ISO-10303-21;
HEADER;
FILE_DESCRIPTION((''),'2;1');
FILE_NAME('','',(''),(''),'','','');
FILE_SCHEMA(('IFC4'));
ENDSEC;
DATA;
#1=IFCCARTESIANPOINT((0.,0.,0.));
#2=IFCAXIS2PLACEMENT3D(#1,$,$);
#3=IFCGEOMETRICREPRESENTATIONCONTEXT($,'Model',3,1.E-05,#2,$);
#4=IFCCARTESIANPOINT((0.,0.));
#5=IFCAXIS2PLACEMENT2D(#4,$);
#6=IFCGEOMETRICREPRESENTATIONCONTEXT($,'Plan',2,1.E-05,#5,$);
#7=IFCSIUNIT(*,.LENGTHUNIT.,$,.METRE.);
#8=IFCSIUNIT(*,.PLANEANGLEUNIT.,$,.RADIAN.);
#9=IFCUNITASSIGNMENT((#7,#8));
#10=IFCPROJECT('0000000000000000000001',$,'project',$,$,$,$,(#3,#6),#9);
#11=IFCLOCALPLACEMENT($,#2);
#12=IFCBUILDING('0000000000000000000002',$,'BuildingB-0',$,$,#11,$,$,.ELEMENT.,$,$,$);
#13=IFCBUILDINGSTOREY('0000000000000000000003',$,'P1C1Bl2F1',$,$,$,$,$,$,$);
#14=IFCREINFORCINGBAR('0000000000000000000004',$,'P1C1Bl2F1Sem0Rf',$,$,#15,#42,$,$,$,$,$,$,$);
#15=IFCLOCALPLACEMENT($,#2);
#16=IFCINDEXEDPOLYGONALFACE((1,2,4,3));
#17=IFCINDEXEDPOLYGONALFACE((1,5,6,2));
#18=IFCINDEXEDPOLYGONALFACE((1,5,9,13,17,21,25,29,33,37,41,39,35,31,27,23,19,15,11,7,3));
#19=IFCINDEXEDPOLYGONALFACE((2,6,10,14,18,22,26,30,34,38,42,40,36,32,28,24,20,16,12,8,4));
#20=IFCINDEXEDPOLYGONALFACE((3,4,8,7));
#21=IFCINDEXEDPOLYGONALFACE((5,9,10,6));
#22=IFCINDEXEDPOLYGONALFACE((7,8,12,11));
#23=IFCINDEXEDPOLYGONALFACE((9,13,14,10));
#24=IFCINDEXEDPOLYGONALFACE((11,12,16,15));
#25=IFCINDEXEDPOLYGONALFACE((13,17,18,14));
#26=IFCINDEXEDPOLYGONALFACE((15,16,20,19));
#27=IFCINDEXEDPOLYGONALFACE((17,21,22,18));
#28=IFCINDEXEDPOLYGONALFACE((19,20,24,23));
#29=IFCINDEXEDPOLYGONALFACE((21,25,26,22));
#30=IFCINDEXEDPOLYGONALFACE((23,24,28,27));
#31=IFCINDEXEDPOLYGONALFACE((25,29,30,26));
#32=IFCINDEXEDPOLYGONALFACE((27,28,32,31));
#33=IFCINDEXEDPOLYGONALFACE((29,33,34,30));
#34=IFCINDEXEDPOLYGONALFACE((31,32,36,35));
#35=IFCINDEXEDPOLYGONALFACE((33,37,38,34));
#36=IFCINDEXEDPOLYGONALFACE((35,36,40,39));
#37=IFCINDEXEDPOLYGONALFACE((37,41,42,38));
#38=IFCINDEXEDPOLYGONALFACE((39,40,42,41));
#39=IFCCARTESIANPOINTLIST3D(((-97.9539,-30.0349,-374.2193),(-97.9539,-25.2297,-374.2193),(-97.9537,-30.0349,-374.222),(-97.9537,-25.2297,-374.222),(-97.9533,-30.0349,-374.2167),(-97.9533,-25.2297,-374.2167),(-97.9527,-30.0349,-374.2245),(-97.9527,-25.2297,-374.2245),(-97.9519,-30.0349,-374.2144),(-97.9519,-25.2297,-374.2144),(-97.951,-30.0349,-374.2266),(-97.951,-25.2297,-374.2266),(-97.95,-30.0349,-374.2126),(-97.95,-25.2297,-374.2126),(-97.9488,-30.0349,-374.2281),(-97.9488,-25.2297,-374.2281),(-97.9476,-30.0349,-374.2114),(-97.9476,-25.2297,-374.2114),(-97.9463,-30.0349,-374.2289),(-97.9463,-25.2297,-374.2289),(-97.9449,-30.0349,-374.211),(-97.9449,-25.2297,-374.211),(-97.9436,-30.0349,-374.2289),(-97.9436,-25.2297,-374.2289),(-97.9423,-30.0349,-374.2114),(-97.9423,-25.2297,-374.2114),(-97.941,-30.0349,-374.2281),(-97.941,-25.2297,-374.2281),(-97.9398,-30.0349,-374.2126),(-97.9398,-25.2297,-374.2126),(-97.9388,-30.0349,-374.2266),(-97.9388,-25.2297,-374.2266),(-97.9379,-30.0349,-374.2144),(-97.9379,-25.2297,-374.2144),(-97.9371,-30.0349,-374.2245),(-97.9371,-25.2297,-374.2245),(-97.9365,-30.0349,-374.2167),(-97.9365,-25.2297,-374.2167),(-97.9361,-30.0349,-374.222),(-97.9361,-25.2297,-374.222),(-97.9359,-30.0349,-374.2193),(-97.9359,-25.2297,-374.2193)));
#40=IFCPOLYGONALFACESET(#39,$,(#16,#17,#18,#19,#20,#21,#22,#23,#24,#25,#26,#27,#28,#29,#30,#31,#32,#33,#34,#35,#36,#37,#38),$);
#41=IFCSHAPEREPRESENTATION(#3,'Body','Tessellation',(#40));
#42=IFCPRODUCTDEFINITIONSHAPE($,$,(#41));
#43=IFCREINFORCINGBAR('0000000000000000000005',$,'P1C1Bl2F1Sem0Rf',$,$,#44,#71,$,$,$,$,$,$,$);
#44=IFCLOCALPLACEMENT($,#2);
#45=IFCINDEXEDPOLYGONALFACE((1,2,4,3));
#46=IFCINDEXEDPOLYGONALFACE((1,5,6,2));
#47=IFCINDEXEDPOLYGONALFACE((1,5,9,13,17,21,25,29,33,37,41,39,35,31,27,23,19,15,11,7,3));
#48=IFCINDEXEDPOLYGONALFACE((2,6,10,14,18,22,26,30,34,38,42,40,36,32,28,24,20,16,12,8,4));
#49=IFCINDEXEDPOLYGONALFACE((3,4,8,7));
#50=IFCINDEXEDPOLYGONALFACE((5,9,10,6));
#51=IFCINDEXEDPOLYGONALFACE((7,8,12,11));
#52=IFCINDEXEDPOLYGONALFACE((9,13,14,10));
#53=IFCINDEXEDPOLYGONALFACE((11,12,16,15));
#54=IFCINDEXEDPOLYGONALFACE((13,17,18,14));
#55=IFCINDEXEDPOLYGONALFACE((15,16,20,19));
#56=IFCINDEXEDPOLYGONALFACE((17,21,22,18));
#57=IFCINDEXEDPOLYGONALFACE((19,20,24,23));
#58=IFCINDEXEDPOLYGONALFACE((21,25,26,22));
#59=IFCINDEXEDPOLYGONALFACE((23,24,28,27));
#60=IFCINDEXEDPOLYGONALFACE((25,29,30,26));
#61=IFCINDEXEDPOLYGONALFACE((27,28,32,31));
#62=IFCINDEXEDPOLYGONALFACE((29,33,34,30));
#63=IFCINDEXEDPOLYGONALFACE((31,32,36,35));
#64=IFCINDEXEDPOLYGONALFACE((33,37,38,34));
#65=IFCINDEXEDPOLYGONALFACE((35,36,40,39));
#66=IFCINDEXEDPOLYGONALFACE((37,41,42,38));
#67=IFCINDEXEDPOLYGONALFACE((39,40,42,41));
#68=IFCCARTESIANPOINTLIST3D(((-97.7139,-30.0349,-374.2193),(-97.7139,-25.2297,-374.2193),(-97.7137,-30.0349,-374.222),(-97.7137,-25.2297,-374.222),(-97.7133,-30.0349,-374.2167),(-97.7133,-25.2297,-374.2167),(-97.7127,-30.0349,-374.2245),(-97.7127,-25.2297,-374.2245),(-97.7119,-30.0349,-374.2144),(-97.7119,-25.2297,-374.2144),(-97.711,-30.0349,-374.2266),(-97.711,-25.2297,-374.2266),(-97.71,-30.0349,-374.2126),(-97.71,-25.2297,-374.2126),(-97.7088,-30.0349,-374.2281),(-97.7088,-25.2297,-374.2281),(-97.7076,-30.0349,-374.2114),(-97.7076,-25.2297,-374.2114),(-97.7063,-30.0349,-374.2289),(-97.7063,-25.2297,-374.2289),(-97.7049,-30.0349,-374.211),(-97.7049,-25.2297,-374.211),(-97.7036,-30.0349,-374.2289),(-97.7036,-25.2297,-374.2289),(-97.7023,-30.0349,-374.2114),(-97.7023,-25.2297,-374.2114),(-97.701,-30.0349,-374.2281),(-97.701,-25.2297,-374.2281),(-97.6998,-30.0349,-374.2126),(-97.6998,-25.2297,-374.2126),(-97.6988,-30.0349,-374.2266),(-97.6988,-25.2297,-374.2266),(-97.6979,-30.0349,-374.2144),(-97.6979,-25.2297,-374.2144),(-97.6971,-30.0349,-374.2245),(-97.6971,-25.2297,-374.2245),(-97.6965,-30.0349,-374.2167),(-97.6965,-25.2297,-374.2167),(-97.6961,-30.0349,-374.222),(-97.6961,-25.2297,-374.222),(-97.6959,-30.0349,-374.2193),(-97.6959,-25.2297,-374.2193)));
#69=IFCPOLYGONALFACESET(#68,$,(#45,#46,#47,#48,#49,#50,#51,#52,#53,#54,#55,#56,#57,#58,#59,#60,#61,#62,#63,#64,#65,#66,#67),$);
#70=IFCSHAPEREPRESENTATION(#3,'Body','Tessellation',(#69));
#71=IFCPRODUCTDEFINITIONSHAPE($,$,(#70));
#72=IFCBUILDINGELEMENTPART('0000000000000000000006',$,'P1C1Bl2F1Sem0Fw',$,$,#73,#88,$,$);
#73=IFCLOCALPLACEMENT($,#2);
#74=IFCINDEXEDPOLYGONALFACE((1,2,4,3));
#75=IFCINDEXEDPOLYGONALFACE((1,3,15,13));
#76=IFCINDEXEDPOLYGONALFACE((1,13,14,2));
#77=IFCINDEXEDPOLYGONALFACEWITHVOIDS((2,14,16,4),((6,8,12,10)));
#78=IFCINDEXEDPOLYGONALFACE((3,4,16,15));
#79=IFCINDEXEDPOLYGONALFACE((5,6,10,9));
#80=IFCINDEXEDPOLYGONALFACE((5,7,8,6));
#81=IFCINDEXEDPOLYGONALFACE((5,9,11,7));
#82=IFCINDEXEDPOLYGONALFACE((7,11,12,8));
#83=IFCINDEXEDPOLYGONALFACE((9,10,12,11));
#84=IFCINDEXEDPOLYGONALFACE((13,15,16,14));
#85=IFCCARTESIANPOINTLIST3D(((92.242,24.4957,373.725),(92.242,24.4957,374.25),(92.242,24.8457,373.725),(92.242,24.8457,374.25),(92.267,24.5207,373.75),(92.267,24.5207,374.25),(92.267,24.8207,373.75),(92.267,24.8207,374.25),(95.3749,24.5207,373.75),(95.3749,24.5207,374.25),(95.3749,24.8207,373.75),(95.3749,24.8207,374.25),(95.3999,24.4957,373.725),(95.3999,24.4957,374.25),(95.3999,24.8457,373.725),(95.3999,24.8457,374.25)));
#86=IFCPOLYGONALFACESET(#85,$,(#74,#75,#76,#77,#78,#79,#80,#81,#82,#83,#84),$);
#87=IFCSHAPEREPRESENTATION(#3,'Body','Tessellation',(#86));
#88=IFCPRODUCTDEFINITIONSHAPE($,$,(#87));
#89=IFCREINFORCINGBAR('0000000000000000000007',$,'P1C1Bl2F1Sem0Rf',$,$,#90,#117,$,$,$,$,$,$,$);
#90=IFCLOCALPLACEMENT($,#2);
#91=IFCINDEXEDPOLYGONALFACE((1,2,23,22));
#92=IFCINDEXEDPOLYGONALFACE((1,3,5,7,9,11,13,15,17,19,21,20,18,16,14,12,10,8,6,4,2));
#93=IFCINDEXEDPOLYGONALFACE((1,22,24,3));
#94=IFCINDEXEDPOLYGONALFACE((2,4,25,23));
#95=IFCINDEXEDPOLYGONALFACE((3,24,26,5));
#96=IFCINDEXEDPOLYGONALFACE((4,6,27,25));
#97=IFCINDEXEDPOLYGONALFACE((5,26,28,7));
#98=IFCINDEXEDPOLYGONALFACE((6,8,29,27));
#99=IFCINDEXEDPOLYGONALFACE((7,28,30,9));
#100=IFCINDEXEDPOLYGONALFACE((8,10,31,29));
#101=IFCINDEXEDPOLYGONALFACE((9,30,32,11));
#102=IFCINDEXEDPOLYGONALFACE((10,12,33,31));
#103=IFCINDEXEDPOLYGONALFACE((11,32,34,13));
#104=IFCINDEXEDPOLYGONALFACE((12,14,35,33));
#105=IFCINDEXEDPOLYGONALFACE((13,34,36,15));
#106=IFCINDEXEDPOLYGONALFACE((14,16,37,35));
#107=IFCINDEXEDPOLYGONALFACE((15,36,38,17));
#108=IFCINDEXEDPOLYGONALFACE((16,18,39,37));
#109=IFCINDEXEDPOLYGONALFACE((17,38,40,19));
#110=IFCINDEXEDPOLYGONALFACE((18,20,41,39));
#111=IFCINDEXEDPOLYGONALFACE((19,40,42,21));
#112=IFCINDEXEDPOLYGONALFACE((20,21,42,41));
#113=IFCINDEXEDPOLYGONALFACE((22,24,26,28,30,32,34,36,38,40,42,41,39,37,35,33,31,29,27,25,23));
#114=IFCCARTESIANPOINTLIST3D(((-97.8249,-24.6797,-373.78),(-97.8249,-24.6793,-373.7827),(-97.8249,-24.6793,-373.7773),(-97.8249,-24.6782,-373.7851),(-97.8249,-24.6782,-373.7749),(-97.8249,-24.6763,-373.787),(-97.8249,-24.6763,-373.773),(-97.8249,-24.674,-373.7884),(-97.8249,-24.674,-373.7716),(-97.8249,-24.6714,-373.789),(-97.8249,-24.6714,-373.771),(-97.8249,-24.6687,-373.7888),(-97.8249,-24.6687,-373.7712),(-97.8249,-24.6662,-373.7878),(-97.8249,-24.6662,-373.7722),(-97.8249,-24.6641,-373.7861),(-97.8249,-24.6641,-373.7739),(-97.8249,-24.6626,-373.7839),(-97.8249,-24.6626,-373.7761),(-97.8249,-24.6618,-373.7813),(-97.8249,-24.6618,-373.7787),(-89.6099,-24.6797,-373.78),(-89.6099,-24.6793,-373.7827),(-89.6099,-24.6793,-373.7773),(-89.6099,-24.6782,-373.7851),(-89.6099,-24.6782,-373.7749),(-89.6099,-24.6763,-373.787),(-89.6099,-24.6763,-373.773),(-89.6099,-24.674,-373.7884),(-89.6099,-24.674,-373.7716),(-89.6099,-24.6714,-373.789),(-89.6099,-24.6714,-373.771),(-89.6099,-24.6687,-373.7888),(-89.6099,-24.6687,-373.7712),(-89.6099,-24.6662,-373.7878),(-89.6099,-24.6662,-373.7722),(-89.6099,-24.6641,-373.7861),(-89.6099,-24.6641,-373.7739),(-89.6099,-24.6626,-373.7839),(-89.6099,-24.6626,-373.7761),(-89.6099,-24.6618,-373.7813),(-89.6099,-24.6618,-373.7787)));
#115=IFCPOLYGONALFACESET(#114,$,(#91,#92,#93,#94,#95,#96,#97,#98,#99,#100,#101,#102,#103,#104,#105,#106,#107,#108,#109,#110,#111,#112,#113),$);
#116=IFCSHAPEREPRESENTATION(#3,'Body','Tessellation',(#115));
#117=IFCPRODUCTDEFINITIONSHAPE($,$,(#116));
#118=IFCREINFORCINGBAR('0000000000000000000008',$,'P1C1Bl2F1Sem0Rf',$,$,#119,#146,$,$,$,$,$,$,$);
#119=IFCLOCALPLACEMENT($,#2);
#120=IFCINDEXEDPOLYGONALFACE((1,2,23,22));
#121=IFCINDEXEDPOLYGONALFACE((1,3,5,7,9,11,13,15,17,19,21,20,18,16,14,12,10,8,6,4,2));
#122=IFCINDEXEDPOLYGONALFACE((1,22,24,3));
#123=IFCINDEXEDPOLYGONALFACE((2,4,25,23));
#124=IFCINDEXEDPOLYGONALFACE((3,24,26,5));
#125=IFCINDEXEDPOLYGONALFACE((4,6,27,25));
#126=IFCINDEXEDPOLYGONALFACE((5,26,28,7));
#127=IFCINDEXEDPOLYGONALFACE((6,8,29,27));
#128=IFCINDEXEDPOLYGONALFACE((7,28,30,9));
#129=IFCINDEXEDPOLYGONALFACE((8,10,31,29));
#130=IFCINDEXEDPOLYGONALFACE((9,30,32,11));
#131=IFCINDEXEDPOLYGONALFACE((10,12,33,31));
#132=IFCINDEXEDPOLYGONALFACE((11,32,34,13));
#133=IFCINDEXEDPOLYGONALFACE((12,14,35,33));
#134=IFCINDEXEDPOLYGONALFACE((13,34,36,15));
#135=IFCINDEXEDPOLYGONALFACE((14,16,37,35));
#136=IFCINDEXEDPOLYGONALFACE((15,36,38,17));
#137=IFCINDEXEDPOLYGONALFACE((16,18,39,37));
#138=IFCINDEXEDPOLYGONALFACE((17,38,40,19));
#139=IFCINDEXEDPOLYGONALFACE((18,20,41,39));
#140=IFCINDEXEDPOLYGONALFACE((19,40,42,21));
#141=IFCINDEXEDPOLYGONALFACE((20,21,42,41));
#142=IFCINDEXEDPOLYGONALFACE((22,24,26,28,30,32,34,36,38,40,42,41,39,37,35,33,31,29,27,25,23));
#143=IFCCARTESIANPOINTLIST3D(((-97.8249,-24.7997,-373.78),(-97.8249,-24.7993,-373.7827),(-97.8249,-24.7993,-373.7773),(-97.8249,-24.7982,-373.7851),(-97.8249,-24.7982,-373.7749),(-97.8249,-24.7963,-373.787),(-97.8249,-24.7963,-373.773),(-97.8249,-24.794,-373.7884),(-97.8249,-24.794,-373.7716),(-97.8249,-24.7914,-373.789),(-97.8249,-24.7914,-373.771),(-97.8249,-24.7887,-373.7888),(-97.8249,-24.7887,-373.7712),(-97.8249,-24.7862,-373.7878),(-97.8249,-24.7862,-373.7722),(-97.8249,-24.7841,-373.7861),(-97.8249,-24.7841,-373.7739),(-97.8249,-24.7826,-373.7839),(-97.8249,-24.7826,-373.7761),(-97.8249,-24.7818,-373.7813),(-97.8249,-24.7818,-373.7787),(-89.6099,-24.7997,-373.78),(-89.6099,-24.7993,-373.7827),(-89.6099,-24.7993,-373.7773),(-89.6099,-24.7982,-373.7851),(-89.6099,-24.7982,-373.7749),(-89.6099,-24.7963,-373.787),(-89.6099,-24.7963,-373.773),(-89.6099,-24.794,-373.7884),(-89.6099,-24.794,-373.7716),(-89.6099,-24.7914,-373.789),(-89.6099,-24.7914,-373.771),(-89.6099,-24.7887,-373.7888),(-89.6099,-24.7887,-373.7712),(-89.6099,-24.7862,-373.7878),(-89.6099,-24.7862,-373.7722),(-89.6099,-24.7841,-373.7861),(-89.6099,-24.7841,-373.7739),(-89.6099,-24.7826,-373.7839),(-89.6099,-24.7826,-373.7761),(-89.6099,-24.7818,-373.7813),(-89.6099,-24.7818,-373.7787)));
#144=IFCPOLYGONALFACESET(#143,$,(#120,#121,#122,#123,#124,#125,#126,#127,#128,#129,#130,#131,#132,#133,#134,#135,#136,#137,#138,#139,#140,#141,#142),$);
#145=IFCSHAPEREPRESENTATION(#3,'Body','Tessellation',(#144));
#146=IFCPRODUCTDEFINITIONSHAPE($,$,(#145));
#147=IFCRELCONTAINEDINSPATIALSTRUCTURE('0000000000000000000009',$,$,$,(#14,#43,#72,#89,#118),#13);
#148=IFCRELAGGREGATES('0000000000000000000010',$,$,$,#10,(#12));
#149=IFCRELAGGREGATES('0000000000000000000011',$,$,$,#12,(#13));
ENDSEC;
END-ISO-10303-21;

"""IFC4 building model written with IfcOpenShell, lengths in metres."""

from ifc_helpers import new_model, entity, si_unit, origin, origin_2d, place, context, project, spatial, polyline, outline, extrude, element, save


model = new_model("IFC4")

# Units and contexts
model_context = context("Model", 3, precision=1e-05, world=origin())
plan_context = context("Plan", 2, precision=1e-05, world=origin_2d())
ifc_project = project(units=[si_unit("LENGTHUNIT", "METRE"), si_unit("PLANEANGLEUNIT", "RADIAN")], contexts=[model_context, plan_context])

# Building, storey
building_placement = place(None, origin())
building = spatial("IfcBuilding", under=ifc_project, at=building_placement, Name="BuildingB-0", CompositionType="ELEMENT")
storey = spatial("IfcBuildingStorey", under=building, Name="P1C1Bl2F1")

# Reinforcing bars
element("IfcReinforcingBar", 1, inside=storey, Name="P1C1Bl2F1Sem0Rf", context=model_context, shape_type="SweptSolid", body=[
    entity("IfcSurfaceCurveSweptAreaSolid", entity("IfcCircleProfileDef", "AREA", None, None, 0.009), None, entity("IfcPolyline", [entity("IfcCartesianPoint", [97.9449, 25.2297, 374.22]), entity("IfcCartesianPoint", [97.9449, 30.0349, 374.22])]), None, None, entity("IfcPlane", entity("IfcAxis2Placement3D", entity("IfcCartesianPoint", [97.9449, 25.2297, 374.22]), entity("IfcDirection", [0.0, 0.0, 1.0]), entity("IfcDirection", [1.0, 0.0, 0.0])))),
])
element("IfcReinforcingBar", 2, inside=storey, Name="P1C1Bl2F1Sem0Rf", context=model_context, shape_type="SweptSolid", body=[
    entity("IfcSurfaceCurveSweptAreaSolid", entity("IfcCircleProfileDef", "AREA", None, None, 0.009), None, entity("IfcPolyline", [entity("IfcCartesianPoint", [97.7049, 25.2297, 374.22]), entity("IfcCartesianPoint", [97.7049, 30.0349, 374.22])]), None, None, entity("IfcPlane", entity("IfcAxis2Placement3D", entity("IfcCartesianPoint", [97.7049, 25.2297, 374.22]), entity("IfcDirection", [0.0, 0.0, 1.0]), entity("IfcDirection", [1.0, 0.0, 0.0])))),
])

# Building element part, opening
building_element_part_1 = element("IfcBuildingElementPart", 3, inside=storey, Name="P1C1Bl2F1Sem0Fw", context=model_context, shape_type="SweptSolid", body=[
    extrude(outline(polyline([(95.3999, 24.4957, 373.725), (95.3999, 24.8457, 373.725), (92.242, 24.8457, 373.725), (92.242, 24.4957, 373.725), (95.3999, 24.4957, 373.725)])), None, (0.0, 0.0, 1.0), 0.525),
])
element("IfcOpeningElement", 4, inside=storey, cuts=building_element_part_1, context=model_context, shape_type="SweptSolid", body=[
    extrude(outline(polyline([(95.3749, 24.5207, 373.75), (95.3749, 24.8207, 373.75), (92.267, 24.8207, 373.75), (92.267, 24.5207, 373.75), (95.3749, 24.5207, 373.75)])), None, (0.0, 0.0, 1.0), 0.5),
])

# Reinforcing bars
element("IfcReinforcingBar", 5, inside=storey, Name="P1C1Bl2F1Sem0Rf", context=model_context, shape_type="SweptSolid", body=[
    entity("IfcSurfaceCurveSweptAreaSolid", entity("IfcCircleProfileDef", "AREA", None, None, 0.009), None, entity("IfcPolyline", [entity("IfcCartesianPoint", [97.8249, 24.6707, 373.78]), entity("IfcCartesianPoint", [89.6099, 24.6707, 373.78])]), None, None, entity("IfcPlane", entity("IfcAxis2Placement3D", entity("IfcCartesianPoint", [97.8249, 24.6707, 373.78]), entity("IfcDirection", [0.0, 0.0, 1.0]), entity("IfcDirection", [1.0, 0.0, 0.0])))),
])
element("IfcReinforcingBar", 6, inside=storey, Name="P1C1Bl2F1Sem0Rf", context=model_context, shape_type="SweptSolid", body=[
    entity("IfcSurfaceCurveSweptAreaSolid", entity("IfcCircleProfileDef", "AREA", None, None, 0.009), None, entity("IfcPolyline", [entity("IfcCartesianPoint", [97.8249, 24.7907, 373.78]), entity("IfcCartesianPoint", [89.6099, 24.7907, 373.78])]), None, None, entity("IfcPlane", entity("IfcAxis2Placement3D", entity("IfcCartesianPoint", [97.8249, 24.7907, 373.78]), entity("IfcDirection", [0.0, 0.0, 1.0]), entity("IfcDirection", [1.0, 0.0, 0.0])))),
])

save(model, "model.ifc")
